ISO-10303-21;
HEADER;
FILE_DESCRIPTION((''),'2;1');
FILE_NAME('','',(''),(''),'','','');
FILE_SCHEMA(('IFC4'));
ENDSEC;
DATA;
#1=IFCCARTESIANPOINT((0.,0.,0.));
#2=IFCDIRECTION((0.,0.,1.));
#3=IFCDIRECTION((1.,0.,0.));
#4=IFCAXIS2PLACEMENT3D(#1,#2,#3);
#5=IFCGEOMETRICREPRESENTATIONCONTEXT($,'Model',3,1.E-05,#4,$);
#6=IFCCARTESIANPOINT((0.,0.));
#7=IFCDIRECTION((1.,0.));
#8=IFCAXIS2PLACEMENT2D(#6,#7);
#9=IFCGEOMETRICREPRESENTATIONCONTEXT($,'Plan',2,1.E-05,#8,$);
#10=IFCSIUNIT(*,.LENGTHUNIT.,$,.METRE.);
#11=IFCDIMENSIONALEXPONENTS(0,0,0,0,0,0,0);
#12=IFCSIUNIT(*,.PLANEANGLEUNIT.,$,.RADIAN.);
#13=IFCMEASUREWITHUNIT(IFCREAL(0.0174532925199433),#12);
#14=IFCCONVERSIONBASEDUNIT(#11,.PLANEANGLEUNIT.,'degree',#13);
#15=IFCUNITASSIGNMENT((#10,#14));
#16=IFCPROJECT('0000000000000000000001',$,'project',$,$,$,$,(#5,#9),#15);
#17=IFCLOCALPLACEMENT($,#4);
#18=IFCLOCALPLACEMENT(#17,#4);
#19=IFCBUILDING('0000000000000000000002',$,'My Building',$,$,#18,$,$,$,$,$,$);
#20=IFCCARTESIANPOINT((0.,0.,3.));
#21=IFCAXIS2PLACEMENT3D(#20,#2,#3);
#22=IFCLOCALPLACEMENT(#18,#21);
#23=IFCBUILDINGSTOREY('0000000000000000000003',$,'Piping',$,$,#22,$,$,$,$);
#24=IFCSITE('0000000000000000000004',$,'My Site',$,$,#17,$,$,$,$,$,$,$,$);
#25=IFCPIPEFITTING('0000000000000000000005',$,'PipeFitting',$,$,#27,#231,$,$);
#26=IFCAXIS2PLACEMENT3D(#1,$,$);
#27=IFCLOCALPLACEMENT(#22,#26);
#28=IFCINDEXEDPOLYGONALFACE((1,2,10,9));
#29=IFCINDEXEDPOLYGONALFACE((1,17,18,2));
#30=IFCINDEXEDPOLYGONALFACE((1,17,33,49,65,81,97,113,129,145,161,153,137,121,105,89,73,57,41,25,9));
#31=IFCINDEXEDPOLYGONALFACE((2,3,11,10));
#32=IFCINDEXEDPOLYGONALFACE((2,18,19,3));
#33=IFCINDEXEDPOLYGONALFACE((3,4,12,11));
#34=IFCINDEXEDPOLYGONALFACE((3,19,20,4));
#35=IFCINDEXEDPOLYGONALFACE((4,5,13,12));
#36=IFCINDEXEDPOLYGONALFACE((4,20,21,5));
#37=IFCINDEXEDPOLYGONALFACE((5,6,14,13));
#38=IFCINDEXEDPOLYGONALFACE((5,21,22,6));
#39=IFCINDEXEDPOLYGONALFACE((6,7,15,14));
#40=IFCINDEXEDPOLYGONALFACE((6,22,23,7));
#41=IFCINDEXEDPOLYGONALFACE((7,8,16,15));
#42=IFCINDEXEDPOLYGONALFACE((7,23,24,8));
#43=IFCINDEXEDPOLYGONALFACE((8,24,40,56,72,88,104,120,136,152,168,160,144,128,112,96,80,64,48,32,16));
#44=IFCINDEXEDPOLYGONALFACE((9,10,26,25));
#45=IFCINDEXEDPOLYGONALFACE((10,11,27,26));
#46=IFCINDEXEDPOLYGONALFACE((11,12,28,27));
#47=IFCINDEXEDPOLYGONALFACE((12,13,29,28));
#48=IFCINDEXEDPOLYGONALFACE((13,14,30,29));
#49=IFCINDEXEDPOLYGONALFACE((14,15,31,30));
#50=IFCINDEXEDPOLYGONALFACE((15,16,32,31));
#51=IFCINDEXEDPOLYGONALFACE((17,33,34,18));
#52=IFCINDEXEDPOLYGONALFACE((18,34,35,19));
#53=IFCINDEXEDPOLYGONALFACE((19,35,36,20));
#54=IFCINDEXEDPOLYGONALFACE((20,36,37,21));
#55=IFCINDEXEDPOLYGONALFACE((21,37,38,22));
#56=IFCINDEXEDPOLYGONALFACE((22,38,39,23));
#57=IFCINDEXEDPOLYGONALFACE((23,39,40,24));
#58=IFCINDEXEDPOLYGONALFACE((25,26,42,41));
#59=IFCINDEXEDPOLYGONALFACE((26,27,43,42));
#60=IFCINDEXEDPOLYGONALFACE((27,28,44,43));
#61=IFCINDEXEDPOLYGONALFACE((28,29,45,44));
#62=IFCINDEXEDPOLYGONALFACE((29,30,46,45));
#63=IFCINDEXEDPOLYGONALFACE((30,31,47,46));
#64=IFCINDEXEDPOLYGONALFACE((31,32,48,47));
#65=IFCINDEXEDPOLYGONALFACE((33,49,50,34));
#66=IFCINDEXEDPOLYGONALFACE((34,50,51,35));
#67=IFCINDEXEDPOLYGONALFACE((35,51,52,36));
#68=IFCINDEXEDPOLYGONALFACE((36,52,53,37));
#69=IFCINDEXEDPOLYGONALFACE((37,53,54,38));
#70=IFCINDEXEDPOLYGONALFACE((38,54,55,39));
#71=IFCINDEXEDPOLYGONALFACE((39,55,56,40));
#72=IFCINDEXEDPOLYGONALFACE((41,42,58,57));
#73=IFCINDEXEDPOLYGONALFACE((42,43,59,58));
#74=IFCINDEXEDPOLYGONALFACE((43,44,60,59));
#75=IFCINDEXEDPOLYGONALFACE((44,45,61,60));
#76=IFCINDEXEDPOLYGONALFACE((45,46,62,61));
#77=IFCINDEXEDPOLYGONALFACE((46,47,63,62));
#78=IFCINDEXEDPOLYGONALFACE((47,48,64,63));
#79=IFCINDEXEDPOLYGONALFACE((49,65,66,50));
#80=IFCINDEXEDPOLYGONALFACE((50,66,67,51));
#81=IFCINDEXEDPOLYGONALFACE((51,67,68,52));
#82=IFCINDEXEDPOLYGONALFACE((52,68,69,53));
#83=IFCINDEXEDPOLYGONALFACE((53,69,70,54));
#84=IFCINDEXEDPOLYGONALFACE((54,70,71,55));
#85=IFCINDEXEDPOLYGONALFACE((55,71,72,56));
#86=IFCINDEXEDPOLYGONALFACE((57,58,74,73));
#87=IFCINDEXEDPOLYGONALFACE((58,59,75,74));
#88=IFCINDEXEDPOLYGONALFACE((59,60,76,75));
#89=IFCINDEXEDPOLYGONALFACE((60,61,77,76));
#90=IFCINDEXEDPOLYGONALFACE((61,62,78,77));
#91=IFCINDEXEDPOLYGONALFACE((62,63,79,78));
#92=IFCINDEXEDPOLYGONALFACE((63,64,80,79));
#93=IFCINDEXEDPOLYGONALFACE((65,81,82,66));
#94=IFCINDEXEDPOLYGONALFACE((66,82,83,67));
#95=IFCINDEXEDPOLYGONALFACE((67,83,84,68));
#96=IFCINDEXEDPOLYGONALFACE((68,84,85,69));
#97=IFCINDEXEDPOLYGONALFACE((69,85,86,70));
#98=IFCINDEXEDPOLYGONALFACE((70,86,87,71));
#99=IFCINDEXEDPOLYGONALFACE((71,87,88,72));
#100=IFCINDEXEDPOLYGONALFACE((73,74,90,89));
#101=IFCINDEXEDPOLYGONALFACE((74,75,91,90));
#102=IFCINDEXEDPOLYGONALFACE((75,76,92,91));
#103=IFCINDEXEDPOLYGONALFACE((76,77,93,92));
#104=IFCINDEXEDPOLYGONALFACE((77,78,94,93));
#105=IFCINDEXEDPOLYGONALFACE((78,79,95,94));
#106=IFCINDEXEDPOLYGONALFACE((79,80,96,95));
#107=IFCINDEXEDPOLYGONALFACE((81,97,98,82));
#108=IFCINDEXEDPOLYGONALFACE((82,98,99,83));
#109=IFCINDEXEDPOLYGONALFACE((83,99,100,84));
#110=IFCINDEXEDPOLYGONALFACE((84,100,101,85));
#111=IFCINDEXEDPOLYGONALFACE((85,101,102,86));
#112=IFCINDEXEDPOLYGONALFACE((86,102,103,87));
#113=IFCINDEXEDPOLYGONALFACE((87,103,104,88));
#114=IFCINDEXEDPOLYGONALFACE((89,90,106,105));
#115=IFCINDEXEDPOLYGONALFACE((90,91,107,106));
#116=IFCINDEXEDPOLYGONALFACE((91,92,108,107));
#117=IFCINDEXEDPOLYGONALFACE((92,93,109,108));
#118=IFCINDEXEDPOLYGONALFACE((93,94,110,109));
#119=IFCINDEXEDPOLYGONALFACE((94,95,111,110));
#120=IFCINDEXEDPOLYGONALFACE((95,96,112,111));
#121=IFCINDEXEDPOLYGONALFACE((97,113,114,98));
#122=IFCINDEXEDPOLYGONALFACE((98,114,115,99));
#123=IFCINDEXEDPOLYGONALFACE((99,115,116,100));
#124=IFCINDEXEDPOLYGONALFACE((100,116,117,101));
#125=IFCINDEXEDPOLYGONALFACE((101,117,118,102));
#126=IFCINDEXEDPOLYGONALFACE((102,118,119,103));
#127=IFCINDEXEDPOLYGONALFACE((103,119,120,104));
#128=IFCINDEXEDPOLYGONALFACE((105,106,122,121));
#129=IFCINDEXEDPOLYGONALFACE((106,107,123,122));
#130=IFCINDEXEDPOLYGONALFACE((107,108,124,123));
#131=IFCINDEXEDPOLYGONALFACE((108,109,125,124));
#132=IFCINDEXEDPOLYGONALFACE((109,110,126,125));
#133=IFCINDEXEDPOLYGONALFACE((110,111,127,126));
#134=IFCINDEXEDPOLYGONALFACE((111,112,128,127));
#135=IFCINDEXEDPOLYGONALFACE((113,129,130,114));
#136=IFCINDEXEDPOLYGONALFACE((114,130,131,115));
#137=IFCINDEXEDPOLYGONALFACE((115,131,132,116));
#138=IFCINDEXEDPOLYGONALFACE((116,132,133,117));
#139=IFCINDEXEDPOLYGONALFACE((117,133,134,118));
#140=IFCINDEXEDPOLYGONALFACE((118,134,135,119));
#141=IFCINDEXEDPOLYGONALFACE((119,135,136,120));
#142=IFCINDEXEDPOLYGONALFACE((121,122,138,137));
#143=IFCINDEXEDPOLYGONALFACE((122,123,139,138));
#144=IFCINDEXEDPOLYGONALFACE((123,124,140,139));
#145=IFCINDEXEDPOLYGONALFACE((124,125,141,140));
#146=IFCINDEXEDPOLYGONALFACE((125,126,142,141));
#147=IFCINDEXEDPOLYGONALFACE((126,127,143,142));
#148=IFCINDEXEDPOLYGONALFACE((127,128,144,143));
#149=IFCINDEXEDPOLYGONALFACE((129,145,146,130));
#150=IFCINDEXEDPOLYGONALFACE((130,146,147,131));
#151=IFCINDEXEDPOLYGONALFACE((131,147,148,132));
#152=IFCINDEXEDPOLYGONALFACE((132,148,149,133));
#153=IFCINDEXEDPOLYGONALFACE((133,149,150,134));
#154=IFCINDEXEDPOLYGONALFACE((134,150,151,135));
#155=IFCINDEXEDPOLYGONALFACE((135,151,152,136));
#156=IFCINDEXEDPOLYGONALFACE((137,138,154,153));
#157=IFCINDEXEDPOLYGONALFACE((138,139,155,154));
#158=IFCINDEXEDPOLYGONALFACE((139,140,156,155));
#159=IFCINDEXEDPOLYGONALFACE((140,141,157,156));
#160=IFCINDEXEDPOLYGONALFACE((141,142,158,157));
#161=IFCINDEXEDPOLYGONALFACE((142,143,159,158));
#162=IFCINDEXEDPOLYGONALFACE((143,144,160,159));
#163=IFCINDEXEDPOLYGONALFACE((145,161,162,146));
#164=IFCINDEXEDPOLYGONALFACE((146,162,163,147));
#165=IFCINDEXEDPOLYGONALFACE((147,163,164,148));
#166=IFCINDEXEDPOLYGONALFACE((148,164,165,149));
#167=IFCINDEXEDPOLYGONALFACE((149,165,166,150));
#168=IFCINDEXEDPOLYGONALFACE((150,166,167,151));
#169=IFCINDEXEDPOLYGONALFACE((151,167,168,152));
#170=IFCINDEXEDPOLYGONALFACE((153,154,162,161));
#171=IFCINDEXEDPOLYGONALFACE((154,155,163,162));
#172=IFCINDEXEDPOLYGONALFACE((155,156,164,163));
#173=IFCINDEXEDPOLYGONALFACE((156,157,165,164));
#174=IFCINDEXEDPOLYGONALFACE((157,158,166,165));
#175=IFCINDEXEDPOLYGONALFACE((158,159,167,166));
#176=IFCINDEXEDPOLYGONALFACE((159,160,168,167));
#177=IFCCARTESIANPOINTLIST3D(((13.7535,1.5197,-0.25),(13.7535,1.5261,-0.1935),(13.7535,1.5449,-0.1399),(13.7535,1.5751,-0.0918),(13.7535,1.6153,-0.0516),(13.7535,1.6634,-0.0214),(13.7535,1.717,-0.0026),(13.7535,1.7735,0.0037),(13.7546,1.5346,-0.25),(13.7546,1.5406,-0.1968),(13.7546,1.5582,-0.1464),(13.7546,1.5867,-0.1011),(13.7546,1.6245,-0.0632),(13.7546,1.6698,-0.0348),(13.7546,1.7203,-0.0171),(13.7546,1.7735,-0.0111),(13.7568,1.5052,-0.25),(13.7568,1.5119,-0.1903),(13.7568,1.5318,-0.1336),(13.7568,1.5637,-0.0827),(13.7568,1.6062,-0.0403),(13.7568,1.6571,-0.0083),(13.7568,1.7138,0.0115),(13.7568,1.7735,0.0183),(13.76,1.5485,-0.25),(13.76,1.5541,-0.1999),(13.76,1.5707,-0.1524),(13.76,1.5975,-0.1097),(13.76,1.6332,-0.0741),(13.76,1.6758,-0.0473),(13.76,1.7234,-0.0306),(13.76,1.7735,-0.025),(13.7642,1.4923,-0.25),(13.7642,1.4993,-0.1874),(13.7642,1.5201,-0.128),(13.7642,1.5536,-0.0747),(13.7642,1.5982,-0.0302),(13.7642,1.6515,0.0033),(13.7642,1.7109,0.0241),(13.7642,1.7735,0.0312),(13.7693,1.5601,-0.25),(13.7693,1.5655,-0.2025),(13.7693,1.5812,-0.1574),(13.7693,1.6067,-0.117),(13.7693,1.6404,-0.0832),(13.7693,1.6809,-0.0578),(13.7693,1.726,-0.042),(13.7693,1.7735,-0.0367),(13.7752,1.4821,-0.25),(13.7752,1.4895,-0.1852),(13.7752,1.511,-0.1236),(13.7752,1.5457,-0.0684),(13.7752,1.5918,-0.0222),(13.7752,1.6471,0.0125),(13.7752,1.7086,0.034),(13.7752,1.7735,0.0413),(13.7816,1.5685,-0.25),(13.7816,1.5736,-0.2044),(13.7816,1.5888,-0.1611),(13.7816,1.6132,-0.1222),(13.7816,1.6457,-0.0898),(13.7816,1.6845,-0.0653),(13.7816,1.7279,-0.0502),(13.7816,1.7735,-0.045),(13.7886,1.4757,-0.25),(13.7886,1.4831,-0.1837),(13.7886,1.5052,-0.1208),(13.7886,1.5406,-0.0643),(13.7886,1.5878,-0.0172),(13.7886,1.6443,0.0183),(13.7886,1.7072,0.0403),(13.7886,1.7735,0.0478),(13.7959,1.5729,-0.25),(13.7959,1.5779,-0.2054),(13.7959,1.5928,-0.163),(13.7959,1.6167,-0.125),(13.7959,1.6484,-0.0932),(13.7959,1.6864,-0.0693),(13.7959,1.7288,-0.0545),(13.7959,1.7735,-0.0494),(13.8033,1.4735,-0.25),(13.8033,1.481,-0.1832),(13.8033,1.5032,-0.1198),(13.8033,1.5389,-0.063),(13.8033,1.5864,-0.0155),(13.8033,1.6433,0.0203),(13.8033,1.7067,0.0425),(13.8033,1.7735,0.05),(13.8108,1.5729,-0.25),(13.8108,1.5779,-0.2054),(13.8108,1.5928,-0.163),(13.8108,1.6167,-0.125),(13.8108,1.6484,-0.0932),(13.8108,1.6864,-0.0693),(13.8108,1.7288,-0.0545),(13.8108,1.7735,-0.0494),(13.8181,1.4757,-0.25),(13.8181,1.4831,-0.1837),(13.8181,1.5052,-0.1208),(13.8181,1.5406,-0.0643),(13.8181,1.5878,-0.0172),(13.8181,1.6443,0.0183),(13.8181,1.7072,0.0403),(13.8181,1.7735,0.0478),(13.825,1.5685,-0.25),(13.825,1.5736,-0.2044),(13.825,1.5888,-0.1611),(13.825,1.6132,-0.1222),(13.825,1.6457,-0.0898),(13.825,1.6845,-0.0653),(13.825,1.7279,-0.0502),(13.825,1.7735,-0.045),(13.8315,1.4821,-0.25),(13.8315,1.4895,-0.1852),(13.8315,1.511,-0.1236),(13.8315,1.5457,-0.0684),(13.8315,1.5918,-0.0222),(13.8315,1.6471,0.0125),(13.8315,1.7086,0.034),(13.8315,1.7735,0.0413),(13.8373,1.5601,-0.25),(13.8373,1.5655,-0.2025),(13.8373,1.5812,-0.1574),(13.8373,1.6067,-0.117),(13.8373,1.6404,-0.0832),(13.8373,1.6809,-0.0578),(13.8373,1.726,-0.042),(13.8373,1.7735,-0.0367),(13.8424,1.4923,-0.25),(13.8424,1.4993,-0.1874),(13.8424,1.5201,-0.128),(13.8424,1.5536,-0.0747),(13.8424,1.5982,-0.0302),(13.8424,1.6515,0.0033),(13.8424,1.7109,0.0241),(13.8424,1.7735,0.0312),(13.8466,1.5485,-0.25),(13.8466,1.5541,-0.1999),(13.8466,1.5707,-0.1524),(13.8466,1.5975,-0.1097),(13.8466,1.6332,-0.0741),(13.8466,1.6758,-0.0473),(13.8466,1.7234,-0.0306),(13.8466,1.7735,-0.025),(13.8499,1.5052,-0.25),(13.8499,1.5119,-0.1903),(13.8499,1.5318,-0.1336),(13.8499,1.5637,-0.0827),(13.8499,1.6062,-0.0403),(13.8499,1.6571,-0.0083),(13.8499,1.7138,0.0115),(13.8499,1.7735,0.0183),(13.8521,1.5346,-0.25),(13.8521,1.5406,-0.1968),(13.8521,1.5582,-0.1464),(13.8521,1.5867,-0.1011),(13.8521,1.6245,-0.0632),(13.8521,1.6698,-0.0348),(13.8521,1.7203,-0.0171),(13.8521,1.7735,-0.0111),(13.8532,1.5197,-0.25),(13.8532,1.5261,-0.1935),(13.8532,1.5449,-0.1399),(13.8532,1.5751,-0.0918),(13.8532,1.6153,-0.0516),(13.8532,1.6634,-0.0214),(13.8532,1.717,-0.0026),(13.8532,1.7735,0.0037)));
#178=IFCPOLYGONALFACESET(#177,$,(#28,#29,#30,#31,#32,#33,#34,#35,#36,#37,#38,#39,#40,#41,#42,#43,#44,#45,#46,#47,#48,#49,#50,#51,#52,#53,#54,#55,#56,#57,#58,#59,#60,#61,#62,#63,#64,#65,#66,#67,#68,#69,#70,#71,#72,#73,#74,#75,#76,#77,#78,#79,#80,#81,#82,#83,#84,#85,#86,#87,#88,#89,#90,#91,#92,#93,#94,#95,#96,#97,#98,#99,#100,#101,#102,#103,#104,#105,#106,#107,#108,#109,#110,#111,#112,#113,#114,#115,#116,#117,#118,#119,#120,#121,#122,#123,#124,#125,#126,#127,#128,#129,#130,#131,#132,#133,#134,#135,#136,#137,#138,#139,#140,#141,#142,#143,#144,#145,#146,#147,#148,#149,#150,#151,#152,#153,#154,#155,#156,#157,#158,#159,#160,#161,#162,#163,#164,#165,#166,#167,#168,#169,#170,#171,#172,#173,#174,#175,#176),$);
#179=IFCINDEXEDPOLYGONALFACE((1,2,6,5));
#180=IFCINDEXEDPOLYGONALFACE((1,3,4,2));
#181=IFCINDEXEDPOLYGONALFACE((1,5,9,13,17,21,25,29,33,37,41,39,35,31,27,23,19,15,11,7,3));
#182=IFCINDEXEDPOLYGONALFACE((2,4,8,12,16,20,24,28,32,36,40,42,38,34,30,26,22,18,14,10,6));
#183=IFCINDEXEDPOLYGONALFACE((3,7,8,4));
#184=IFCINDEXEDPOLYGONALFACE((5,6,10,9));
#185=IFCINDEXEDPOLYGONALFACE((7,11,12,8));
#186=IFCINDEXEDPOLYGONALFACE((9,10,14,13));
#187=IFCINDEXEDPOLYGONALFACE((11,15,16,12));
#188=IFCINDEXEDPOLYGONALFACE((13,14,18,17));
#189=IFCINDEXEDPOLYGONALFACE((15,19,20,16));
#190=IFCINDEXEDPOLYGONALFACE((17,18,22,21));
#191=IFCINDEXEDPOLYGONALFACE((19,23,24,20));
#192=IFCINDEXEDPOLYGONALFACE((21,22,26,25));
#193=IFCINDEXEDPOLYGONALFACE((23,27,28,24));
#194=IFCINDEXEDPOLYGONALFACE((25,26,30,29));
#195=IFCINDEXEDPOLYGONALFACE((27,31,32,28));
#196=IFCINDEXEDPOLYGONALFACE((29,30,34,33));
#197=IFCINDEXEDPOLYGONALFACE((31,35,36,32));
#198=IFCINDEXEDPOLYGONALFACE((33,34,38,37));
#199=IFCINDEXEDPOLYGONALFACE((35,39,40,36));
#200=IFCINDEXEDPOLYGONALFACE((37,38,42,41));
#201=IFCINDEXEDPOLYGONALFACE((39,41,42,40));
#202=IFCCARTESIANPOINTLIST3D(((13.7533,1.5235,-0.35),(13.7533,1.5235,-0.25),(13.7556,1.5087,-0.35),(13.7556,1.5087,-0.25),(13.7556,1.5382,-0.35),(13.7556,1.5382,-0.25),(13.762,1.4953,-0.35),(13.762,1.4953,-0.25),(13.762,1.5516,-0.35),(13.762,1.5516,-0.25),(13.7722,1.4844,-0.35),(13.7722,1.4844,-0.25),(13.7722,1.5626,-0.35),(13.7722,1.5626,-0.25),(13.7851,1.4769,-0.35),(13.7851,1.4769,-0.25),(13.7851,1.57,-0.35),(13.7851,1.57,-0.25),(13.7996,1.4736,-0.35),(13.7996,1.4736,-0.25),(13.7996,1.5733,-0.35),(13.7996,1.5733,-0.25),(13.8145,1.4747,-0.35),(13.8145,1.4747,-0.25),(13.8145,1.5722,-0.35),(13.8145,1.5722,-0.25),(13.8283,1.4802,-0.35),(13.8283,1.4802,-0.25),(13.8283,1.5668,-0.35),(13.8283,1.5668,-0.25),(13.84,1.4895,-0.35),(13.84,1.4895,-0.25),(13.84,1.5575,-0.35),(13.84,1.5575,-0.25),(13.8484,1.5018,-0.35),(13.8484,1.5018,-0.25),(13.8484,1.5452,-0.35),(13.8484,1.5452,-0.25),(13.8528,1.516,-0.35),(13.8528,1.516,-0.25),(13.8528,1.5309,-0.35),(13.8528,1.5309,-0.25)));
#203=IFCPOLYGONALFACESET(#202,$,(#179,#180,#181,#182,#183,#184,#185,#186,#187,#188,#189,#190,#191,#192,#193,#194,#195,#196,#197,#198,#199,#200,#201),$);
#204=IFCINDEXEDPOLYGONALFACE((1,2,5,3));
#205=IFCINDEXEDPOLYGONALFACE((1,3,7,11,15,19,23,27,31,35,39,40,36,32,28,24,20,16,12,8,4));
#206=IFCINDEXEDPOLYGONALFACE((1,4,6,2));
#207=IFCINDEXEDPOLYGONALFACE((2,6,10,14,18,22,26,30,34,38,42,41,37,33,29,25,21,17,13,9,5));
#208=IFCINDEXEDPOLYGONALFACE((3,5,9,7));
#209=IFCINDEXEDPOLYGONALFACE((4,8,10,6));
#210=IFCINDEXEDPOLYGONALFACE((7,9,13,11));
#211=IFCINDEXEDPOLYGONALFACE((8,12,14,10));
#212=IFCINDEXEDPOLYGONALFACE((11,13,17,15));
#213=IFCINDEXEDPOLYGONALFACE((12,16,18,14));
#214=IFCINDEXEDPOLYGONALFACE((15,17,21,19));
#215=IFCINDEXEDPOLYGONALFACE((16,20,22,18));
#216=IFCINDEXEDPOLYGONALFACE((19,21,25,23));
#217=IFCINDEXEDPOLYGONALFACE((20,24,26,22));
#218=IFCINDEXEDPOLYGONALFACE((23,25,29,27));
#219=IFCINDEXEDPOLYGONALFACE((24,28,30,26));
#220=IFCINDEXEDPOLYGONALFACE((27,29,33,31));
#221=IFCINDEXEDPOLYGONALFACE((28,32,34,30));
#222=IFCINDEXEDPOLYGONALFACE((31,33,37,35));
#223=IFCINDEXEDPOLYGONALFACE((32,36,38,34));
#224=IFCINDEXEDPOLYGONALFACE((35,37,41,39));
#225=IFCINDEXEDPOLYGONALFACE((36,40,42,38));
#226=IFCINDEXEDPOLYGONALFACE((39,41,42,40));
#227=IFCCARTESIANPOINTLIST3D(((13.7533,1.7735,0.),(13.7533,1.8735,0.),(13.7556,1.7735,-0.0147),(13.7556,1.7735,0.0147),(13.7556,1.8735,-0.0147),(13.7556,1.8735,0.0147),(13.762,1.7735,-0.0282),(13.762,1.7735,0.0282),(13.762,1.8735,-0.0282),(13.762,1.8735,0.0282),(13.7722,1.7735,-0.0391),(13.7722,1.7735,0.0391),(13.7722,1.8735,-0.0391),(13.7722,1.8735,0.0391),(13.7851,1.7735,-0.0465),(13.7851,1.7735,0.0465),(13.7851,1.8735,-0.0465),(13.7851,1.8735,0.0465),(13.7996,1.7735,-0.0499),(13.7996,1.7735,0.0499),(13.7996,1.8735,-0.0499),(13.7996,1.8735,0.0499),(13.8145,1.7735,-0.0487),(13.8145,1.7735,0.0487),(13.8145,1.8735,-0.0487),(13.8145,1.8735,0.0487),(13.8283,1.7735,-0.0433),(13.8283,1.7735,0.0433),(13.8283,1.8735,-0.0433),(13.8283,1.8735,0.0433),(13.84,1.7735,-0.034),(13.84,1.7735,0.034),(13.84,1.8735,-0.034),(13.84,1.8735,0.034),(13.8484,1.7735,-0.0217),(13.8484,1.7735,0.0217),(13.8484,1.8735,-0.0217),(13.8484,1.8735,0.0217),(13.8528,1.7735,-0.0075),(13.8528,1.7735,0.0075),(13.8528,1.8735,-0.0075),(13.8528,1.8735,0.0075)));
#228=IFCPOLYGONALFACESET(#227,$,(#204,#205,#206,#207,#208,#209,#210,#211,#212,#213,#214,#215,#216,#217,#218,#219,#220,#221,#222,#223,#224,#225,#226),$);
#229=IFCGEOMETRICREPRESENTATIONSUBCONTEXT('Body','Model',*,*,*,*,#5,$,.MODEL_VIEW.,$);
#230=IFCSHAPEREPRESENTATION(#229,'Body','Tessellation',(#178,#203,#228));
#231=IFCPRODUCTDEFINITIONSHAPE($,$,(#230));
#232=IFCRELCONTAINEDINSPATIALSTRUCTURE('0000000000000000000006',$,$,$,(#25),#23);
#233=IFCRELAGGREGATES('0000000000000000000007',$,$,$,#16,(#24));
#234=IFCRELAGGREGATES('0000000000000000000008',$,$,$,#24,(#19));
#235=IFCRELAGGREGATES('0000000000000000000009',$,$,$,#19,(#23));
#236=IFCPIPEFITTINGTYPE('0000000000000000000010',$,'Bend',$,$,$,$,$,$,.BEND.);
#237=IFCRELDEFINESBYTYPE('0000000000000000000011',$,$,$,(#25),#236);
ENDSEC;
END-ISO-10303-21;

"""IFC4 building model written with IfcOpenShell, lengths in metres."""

from ifc_helpers import new_model, entity, si_unit, converted_unit, frame, origin_with_axes, origin_2d_with_axis, place, context, subcontext, project, spatial, line, indexed_curve, circle, outline, extrude, source, transform, mapped, type_object, type_shapes, element, save


model = new_model("IFC4")

# Units and contexts
model_context = context("Model", 3, precision=1e-05, world=origin_with_axes())
plan_context = context("Plan", 2, precision=1e-05, world=origin_2d_with_axis())
body_context = subcontext(model_context, "Body", "Model", "MODEL_VIEW")
ifc_project = project(units=[si_unit("LENGTHUNIT", "METRE"), converted_unit("PLANEANGLEUNIT", "degree", entity("IfcReal", 0.0174532925199433), si_unit("PLANEANGLEUNIT", "RADIAN"), dimensions=[0, 0, 0, 0, 0, 0, 0])], contexts=[model_context, plan_context])

# Site, building, storey
site_placement = place(None, origin_with_axes())
site = spatial("IfcSite", under=ifc_project, at=site_placement, Name="My Site")
building_placement = place(site_placement, origin_with_axes())
building = spatial("IfcBuilding", under=site, at=building_placement, Name="My Building")
storey_placement = place(building_placement, frame((0.0, 0.0, 3.0), z_axis=(0.0, 0.0, 1.0), x_axis=(1.0, 0.0, 0.0)))
storey = spatial("IfcBuildingStorey", under=building, at=storey_placement, Name="Piping")

# Pipe fitting, opening
pipe_fitting_type = type_object("IfcPipeFittingType", Name="Bend", PredefinedType="BEND")
shared_shape = source(origin_with_axes(), body_context, "Body", "SolidModel", [
    entity("IfcSweptDiskSolid", entity("IfcIndexedPolyCurve", entity("IfcCartesianPointList3D", [[0.0, 0.0, -0.1], [0.0, 0.0732, -0.2768], [0.0, 0.25, -0.35]]), [entity("IfcArcIndex", [1, 2, 3])]), 0.05),
    extrude(circle(Radius=0.05), origin_with_axes(), (0.0, 0.0, -1.0), 0.1),
    extrude(circle(Radius=0.05), frame((0.0, 0.25, -0.35), z_axis=(0.0, 1.0, 0.0), x_axis=(1.0, 0.0, 0.0)), (0.0, 0.0, 1.0), 0.1),
])
type_shapes(pipe_fitting_type, [shared_shape])
pipe_fitting_1_placement = place(storey_placement, frame((13.8033, 1.5235, -0.35), z_axis=(0.0, 0.0, -1.0), x_axis=(-1.0, 0.0, 0.0)))
pipe_fitting_1 = element("IfcPipeFitting", 1, at=pipe_fitting_1_placement, inside=storey, type_object=pipe_fitting_type, Name="PipeFitting", context=body_context, shape_type="MappedRepresentation", body=[
    mapped(shared_shape, transform((0.0, 0.0, 0.0), x_axis=(1.0, 0.0, 0.0), y_axis=(0.0, 1.0, 0.0), z_axis=(0.0, 0.0, 1.0), scale=1.0)),
])
opening_1_placement = place(pipe_fitting_1_placement, frame((1.9673, -1.5235, 2.65), z_axis=(0.0, 0.0, -1.0), x_axis=(-1.0, 0.0, 0.0)))
element("IfcOpeningElement", 2, at=opening_1_placement, cuts=pipe_fitting_1, PredefinedType="OPENING", context=body_context, shape_type="SweptSolid", body=[
    extrude(outline(indexed_curve([(0.0, 0.0), (0.5, 0.0), (0.5, 0.5), (0.0, 0.5)], segments=[line(1, 2, 3, 4, 1)])), origin_with_axes(), (0.0, 0.0, 1.0), 0.5),
])

save(model, "model.ifc")
